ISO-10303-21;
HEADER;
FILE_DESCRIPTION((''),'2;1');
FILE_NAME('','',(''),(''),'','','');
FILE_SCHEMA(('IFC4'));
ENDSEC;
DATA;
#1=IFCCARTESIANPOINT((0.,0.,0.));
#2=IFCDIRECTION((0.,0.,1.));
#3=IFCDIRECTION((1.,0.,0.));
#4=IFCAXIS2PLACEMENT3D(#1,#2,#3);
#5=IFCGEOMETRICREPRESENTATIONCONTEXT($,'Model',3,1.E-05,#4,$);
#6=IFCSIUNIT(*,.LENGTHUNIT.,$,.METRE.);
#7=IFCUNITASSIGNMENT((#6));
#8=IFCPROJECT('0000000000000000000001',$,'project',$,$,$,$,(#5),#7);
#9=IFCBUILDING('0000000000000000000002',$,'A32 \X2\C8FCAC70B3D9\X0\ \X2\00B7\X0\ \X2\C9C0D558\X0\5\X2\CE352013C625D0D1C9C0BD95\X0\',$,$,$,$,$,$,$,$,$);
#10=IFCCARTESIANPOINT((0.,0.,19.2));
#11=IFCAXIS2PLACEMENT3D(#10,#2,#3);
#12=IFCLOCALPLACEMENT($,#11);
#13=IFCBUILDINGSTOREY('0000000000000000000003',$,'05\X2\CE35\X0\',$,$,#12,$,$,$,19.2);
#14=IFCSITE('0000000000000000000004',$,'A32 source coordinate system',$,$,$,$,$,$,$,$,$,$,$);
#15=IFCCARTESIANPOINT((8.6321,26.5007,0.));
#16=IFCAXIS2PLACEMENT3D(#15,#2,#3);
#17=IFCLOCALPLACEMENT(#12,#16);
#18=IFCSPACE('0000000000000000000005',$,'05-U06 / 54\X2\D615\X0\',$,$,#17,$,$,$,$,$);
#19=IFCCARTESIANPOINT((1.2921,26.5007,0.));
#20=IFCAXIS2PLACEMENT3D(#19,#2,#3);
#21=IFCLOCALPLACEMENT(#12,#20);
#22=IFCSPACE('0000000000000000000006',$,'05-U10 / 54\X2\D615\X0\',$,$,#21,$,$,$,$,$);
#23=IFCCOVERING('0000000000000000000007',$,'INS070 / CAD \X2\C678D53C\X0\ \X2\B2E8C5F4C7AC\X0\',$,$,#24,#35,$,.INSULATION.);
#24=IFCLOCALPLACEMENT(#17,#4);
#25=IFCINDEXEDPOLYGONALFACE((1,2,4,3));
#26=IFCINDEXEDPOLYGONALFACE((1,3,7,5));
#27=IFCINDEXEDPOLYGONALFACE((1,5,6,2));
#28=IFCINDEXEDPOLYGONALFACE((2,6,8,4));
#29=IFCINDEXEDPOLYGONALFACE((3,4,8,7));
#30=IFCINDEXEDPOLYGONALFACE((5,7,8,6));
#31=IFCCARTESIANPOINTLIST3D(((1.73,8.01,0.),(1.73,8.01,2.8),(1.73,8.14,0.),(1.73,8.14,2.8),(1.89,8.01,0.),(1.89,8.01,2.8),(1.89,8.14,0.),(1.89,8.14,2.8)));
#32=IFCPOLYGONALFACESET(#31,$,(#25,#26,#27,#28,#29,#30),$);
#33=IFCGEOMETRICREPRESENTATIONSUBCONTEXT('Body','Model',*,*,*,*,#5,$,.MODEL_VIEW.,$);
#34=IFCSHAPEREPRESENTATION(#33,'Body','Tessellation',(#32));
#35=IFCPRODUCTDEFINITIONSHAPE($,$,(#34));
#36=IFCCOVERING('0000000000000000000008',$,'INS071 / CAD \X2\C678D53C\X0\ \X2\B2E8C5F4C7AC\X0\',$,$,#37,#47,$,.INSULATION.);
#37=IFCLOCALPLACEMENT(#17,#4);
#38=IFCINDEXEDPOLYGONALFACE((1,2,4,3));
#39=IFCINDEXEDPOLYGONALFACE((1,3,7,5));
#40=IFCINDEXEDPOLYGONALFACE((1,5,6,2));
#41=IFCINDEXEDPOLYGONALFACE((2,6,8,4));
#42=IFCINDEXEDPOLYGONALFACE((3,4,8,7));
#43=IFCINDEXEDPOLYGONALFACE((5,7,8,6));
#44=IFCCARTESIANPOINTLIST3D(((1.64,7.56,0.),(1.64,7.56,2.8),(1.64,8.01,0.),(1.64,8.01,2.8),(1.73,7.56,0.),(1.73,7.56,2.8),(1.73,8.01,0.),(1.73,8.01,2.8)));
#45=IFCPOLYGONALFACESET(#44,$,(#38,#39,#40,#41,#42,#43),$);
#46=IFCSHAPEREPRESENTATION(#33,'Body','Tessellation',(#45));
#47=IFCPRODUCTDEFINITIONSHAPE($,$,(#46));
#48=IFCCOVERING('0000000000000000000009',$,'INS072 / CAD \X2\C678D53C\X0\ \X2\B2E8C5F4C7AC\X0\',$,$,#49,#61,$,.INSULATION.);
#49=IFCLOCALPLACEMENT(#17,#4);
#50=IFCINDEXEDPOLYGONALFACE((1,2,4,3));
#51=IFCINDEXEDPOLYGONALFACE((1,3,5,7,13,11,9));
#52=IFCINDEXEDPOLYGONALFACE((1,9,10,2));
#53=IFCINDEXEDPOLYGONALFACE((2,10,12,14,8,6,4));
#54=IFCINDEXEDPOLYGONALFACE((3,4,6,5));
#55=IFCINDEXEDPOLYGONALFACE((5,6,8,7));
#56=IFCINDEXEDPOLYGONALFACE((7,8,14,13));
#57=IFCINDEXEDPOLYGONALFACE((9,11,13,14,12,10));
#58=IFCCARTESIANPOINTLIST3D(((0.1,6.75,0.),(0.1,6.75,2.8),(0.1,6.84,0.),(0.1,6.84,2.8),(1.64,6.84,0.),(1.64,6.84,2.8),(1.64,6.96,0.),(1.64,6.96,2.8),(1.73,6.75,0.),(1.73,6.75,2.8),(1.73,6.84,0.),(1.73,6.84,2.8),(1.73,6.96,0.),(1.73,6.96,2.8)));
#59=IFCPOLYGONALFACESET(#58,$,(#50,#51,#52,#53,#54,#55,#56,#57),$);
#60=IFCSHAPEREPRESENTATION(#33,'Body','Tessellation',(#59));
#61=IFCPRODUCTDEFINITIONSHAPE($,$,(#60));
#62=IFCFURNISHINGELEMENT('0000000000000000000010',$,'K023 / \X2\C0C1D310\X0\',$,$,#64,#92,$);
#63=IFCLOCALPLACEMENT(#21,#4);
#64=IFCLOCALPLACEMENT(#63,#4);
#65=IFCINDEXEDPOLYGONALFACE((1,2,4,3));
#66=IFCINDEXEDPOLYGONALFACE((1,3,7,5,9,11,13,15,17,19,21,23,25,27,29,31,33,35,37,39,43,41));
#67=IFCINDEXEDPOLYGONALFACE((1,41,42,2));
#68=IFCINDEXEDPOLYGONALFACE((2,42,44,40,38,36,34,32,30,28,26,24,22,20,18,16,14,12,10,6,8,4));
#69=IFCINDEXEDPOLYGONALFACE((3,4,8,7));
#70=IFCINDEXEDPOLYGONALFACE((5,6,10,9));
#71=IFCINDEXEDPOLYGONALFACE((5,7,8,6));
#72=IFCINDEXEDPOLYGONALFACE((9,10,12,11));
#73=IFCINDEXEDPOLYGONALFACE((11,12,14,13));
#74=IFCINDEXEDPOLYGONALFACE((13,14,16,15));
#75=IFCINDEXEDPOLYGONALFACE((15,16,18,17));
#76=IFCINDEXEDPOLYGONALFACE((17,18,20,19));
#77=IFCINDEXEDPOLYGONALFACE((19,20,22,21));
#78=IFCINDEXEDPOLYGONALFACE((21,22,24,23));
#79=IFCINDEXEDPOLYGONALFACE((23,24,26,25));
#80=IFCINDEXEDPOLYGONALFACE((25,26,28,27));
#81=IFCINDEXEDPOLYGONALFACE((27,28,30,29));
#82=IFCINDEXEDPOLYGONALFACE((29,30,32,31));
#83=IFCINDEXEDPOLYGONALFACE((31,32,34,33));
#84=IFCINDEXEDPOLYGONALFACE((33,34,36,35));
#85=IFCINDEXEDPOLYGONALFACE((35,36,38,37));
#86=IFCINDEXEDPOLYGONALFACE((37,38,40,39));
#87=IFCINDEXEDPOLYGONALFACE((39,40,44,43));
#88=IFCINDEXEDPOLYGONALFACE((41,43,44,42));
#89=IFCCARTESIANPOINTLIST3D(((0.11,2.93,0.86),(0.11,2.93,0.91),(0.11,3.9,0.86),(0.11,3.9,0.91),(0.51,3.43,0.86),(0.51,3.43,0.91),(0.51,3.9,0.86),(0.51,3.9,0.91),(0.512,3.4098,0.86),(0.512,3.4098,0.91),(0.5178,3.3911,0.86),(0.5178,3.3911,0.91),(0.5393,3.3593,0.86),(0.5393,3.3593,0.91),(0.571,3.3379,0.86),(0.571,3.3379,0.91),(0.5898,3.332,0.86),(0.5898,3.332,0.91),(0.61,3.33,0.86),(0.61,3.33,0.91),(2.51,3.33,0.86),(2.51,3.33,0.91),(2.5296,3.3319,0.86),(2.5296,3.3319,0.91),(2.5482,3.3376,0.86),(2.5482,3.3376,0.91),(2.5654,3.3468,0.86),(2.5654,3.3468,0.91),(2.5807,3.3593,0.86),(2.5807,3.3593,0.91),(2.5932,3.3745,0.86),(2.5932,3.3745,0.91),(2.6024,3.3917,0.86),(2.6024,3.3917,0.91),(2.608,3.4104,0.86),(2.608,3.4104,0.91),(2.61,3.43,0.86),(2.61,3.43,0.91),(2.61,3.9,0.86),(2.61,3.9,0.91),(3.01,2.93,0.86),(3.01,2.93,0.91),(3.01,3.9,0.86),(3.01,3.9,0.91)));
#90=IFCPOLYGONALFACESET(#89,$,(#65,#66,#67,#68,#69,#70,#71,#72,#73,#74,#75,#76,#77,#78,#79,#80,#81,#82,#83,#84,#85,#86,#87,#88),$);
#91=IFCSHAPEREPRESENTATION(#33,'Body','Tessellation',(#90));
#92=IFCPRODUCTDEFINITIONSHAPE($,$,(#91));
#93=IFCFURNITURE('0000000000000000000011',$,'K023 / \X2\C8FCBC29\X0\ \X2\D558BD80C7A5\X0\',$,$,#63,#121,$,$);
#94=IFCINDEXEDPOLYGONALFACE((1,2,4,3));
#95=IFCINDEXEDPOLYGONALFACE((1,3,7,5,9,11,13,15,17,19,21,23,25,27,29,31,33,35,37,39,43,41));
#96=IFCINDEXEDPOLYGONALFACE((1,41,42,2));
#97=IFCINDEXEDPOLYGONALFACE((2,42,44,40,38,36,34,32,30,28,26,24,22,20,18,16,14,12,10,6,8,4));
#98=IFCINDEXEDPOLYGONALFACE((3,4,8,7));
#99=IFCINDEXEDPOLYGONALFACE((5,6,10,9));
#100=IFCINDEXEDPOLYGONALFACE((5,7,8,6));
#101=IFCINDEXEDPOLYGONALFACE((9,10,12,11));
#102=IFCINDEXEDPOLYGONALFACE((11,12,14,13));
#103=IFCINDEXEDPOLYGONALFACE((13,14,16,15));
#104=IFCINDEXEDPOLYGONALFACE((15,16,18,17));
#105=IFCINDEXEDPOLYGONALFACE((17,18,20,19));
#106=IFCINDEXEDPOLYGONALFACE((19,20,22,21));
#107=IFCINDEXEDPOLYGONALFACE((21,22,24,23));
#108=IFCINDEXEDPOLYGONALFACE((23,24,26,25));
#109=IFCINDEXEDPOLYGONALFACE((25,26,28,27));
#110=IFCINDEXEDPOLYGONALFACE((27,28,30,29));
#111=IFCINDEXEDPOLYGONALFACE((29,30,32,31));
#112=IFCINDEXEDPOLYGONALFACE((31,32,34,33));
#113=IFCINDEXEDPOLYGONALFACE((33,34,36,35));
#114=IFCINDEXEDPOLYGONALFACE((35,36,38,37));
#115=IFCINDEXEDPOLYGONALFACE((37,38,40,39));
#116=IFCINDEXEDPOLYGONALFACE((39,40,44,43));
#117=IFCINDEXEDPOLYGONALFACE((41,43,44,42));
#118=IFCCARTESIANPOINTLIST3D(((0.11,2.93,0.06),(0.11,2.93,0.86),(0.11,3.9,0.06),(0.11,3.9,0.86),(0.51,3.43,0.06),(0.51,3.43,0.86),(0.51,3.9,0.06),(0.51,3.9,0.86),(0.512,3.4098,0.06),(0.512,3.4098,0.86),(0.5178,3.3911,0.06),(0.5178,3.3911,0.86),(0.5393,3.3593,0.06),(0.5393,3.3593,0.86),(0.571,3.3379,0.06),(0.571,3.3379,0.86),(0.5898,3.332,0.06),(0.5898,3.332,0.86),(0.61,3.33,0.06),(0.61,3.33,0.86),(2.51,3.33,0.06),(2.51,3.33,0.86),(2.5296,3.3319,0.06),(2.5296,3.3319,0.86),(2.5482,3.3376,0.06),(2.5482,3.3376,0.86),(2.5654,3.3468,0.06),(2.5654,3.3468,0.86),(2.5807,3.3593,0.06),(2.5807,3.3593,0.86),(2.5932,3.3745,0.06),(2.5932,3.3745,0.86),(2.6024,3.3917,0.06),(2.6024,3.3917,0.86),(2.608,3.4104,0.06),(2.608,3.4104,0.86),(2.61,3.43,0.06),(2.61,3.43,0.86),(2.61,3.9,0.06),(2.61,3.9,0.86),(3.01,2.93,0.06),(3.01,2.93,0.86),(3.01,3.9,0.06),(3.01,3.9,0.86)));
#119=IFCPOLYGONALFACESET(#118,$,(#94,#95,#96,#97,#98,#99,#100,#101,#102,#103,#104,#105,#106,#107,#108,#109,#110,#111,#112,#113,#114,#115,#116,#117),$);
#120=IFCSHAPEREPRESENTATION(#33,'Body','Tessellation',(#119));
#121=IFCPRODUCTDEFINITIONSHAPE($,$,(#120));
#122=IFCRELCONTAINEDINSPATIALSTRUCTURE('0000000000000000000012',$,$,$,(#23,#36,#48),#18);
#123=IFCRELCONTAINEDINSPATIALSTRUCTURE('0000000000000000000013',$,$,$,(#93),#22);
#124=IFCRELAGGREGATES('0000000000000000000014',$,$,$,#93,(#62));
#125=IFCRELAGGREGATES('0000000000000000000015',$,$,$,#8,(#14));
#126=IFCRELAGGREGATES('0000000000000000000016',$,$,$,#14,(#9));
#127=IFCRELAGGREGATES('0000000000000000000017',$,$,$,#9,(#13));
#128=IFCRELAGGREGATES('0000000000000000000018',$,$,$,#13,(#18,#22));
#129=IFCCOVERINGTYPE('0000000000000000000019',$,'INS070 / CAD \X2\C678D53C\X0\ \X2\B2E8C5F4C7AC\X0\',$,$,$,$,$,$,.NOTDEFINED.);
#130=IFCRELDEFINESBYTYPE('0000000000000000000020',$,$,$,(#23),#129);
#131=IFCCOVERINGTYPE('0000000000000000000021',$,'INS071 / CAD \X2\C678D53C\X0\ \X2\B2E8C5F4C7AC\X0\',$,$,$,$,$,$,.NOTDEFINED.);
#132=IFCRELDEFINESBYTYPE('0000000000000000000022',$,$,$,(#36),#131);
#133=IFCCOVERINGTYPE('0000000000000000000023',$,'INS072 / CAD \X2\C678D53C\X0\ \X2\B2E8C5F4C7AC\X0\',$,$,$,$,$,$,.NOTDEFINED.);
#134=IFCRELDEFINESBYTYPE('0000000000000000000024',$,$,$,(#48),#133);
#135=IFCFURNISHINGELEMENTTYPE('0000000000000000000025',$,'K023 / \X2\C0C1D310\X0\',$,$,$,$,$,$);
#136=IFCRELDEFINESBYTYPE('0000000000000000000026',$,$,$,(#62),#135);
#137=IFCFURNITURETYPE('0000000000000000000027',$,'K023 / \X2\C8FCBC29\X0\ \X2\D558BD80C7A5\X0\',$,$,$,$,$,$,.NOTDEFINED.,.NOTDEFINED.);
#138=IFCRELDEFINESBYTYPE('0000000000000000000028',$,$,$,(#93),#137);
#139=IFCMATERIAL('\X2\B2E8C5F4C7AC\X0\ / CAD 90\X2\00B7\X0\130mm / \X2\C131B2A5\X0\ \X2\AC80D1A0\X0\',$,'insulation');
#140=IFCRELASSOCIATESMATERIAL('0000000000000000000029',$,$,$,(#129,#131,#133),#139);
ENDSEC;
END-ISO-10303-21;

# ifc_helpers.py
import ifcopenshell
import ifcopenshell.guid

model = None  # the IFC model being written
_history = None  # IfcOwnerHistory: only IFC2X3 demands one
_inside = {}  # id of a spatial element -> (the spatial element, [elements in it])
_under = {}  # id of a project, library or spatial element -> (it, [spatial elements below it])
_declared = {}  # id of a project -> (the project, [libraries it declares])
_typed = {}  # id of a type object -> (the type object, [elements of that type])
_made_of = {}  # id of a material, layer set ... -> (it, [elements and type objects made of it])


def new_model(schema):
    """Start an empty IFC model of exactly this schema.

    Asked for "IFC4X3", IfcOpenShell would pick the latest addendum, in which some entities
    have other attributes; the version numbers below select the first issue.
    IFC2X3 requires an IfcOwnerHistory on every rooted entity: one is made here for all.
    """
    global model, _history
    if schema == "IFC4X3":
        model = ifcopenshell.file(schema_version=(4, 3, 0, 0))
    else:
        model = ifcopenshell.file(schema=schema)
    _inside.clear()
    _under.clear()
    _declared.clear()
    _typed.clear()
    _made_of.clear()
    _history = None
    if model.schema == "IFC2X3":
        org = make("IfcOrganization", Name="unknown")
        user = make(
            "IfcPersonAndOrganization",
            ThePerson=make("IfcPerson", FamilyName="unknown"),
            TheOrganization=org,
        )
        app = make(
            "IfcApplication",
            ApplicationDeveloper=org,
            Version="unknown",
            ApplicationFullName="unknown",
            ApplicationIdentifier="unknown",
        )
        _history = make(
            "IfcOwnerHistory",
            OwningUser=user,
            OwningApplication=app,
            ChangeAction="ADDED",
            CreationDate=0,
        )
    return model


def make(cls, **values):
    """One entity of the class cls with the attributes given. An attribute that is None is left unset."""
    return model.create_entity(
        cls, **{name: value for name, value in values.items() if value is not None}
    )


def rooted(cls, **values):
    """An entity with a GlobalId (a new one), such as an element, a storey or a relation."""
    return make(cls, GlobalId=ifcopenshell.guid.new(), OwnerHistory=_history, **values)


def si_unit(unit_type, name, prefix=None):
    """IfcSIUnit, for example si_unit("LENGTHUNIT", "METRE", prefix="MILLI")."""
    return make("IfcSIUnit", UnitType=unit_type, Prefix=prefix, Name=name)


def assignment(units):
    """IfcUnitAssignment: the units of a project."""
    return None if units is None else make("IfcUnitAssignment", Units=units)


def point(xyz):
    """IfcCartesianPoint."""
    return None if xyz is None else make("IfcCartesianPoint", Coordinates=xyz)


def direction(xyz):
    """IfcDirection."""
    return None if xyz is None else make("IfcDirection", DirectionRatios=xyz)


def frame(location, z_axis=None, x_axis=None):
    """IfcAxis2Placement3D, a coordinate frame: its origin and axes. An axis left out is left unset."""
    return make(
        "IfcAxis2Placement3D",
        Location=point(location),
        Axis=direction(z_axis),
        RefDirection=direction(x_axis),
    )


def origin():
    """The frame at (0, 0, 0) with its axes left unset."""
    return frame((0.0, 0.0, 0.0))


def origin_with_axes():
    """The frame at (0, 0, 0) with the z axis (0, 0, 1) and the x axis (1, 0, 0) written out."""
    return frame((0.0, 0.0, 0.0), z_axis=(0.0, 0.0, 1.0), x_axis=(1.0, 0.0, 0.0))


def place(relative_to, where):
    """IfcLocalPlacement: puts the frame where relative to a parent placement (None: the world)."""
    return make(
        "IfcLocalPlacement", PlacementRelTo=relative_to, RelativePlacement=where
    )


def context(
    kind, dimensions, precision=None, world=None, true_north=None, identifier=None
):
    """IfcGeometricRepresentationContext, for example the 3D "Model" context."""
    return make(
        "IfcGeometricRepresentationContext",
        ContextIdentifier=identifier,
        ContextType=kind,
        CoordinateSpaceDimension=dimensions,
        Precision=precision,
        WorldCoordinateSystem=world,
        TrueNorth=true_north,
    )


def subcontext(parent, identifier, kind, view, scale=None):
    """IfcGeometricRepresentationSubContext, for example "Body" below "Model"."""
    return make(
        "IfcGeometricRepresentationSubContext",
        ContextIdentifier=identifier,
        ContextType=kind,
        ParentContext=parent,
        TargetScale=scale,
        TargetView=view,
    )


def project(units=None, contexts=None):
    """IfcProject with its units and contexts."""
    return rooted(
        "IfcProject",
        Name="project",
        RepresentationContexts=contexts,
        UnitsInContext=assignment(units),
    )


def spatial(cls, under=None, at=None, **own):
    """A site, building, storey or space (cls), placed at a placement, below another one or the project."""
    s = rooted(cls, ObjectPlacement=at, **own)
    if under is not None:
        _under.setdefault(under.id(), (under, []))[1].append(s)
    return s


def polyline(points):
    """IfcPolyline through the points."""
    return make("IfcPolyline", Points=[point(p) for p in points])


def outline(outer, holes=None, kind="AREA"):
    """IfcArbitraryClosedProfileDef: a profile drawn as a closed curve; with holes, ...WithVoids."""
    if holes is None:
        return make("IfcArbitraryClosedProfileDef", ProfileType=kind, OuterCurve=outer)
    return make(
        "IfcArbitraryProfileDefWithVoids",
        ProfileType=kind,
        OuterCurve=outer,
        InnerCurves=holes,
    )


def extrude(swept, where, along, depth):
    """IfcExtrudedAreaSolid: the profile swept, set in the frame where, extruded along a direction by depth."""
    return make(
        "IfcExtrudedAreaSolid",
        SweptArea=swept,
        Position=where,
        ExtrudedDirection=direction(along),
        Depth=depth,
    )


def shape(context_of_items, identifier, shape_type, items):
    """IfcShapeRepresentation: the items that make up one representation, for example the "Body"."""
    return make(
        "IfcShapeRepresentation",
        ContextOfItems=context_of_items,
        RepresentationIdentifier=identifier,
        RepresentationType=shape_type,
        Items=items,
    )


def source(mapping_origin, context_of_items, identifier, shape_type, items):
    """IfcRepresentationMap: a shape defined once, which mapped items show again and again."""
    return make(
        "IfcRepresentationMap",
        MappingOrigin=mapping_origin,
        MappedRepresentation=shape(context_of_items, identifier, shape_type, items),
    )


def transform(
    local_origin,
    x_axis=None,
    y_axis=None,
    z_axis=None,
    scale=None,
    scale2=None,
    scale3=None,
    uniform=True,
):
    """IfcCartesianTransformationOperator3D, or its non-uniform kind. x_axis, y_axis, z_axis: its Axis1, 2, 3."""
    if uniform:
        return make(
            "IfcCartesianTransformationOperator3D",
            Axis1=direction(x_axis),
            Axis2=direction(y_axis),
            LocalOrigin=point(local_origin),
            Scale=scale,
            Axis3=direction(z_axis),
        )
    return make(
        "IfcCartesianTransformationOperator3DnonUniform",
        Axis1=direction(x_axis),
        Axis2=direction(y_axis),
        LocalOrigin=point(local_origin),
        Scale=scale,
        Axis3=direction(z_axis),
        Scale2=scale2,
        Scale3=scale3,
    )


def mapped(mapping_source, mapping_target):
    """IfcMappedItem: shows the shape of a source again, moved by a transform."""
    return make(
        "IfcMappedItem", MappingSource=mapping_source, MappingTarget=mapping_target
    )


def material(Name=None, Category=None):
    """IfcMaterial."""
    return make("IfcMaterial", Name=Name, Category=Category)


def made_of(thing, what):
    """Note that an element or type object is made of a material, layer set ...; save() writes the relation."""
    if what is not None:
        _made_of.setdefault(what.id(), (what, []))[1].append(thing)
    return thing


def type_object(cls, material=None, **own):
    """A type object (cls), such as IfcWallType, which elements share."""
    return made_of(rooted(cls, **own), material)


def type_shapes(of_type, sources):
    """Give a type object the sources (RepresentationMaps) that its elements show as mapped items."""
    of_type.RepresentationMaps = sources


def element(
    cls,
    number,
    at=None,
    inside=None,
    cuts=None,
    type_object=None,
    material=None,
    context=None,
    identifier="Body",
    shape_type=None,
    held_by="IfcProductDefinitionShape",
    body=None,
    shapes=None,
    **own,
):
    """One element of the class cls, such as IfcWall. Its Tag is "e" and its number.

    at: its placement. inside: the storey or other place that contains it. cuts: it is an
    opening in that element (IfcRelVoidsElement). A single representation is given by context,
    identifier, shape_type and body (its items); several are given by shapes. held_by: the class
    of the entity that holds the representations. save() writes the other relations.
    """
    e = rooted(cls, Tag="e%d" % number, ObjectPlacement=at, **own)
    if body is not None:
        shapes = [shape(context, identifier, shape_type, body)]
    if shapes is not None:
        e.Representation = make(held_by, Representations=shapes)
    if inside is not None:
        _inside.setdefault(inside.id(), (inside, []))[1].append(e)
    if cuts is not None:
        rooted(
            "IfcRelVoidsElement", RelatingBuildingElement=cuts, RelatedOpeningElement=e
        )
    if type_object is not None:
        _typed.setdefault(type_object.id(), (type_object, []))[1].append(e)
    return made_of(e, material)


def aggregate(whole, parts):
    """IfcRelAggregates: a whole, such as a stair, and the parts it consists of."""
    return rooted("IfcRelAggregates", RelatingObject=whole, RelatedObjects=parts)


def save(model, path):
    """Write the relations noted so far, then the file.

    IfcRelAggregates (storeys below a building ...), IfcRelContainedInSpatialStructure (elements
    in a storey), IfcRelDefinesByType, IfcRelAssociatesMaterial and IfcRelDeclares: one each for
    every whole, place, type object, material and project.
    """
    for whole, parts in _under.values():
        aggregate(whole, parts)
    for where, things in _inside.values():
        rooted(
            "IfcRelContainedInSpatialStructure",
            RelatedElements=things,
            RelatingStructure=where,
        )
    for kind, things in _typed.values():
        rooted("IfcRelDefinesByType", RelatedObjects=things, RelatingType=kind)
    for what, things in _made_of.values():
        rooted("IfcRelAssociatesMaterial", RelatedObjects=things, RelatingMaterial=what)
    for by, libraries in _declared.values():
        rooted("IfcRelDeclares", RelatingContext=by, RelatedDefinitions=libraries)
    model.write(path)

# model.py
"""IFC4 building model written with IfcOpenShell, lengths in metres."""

from ifc_helpers import new_model, si_unit, frame, origin, origin_with_axes, place, context, subcontext, project, spatial, polyline, outline, extrude, source, transform, mapped, material, type_object, type_shapes, element, aggregate, save


model = new_model("IFC4")

# Units and contexts
model_context = context("Model", 3, precision=1e-05, world=origin_with_axes())
body_context = subcontext(model_context, "Body", "Model", "MODEL_VIEW")
ifc_project = project(units=[si_unit("LENGTHUNIT", "METRE")], contexts=[model_context])

# Site, building, storey, space
storey_placement = place(None, frame((0.0, 0.0, 19.2), z_axis=(0.0, 0.0, 1.0), x_axis=(1.0, 0.0, 0.0)))
space_1_placement = place(storey_placement, frame((8.6321, 26.5007, 0.0), z_axis=(0.0, 0.0, 1.0), x_axis=(1.0, 0.0, 0.0)))
site = spatial("IfcSite", under=ifc_project, Name="A32 source coordinate system")
building = spatial("IfcBuilding", under=site, Name="A32 주거동 · 지하5층–옥탑지붕")
storey = spatial("IfcBuildingStorey", under=building, at=storey_placement, Name="05층", Elevation=19.2)
space_1 = spatial("IfcSpace", under=storey, at=space_1_placement, Name="05-U06 / 54형")

# Coverings
ifc_material = material(Name="단열재 / CAD 90·130mm / 성능 검토", Category="insulation")
covering_type_1 = type_object("IfcCoveringType", Name="INS070 / CAD 외피 단열재", PredefinedType="NOTDEFINED", material=ifc_material)
shared_shape_1 = source(origin(), body_context, "Body", "SweptSolid", [
    extrude(outline(polyline([(1.73, 8.14), (1.89, 8.14), (1.89, 8.01), (1.73, 8.01), (1.73, 8.14)])), origin(), (0.0, 0.0, 1.0), 2.8),
])
type_shapes(covering_type_1, [shared_shape_1])
covering_1_placement = place(space_1_placement, origin_with_axes())
element("IfcCovering", 1, at=covering_1_placement, inside=space_1, type_object=covering_type_1, Name="INS070 / CAD 외피 단열재", PredefinedType="INSULATION", context=body_context, shape_type="MappedRepresentation", body=[
    mapped(shared_shape_1, transform((0.0, 0.0, 0.0), scale=1.0)),
])
covering_type_2 = type_object("IfcCoveringType", Name="INS071 / CAD 외피 단열재", PredefinedType="NOTDEFINED", material=ifc_material)
shared_shape_2 = source(origin(), body_context, "Body", "SweptSolid", [
    extrude(outline(polyline([(1.73, 7.56), (1.64, 7.56), (1.64, 8.01), (1.73, 8.01), (1.73, 7.56)])), origin(), (0.0, 0.0, 1.0), 2.8),
])
type_shapes(covering_type_2, [shared_shape_2])
covering_2_placement = place(space_1_placement, origin_with_axes())
element("IfcCovering", 2, at=covering_2_placement, inside=space_1, type_object=covering_type_2, Name="INS071 / CAD 외피 단열재", PredefinedType="INSULATION", context=body_context, shape_type="MappedRepresentation", body=[
    mapped(shared_shape_2, transform((0.0, 0.0, 0.0), scale=1.0)),
])
covering_type_3 = type_object("IfcCoveringType", Name="INS072 / CAD 외피 단열재", PredefinedType="NOTDEFINED", material=ifc_material)
shared_shape_3 = source(origin(), body_context, "Body", "SweptSolid", [
    extrude(outline(polyline([(1.64, 6.84), (1.64, 6.96), (1.73, 6.96), (1.73, 6.84), (1.73, 6.75), (0.1, 6.75), (0.1, 6.84), (1.64, 6.84)])), origin(), (0.0, 0.0, 1.0), 2.8),
])
type_shapes(covering_type_3, [shared_shape_3])
covering_3_placement = place(space_1_placement, origin_with_axes())
element("IfcCovering", 3, at=covering_3_placement, inside=space_1, type_object=covering_type_3, Name="INS072 / CAD 외피 단열재", PredefinedType="INSULATION", context=body_context, shape_type="MappedRepresentation", body=[
    mapped(shared_shape_3, transform((0.0, 0.0, 0.0), scale=1.0)),
])

# Shared definitions
space_2_placement = place(storey_placement, frame((1.2921, 26.5007, 0.0), z_axis=(0.0, 0.0, 1.0), x_axis=(1.0, 0.0, 0.0)))

# Furnishing element
furnishing_element_type_1 = type_object("IfcFurnishingElementType", Name="K023 / 상판")
shared_shape_4 = source(origin(), body_context, "Body", "SweptSolid", [
    extrude(outline(polyline([(0.51, 3.43), (0.512, 3.4098), (0.5178, 3.3911), (0.5393, 3.3593), (0.571, 3.3379), (0.5898, 3.332), (0.61, 3.33), (2.51, 3.33), (2.5296, 3.3319), (2.5482, 3.3376), (2.5654, 3.3468), (2.5807, 3.3593), (2.5932, 3.3745), (2.6024, 3.3917), (2.608, 3.4104), (2.61, 3.43), (2.61, 3.9), (3.01, 3.9), (3.01, 2.93), (0.11, 2.93), (0.11, 3.9), (0.51, 3.9), (0.51, 3.43)])), frame((0.0, 0.0, 0.86)), (0.0, 0.0, 1.0), 0.05),
])
type_shapes(furnishing_element_type_1, [shared_shape_4])
furniture_1_placement = place(space_2_placement, origin_with_axes())
furnishing_1_placement = place(furniture_1_placement, origin_with_axes())
furnishing_1 = element("IfcFurnishingElement", 4, at=furnishing_1_placement, type_object=furnishing_element_type_1, Name="K023 / 상판", context=body_context, shape_type="MappedRepresentation", body=[
    mapped(shared_shape_4, transform((0.0, 0.0, 0.0), scale=1.0)),
])

# Shared definitions
space_2 = spatial("IfcSpace", under=storey, at=space_2_placement, Name="05-U10 / 54형")

# Furniture
furniture_type_1 = type_object("IfcFurnitureType", Name="K023 / 주방 하부장", AssemblyPlace="NOTDEFINED", PredefinedType="NOTDEFINED")
shared_shape_5 = source(origin(), body_context, "Body", "SweptSolid", [
    extrude(outline(polyline([(0.51, 3.9), (0.51, 3.43), (0.512, 3.4098), (0.5178, 3.3911), (0.5393, 3.3593), (0.571, 3.3379), (0.5898, 3.332), (0.61, 3.33), (2.51, 3.33), (2.5296, 3.3319), (2.5482, 3.3376), (2.5654, 3.3468), (2.5807, 3.3593), (2.5932, 3.3745), (2.6024, 3.3917), (2.608, 3.4104), (2.61, 3.43), (2.61, 3.9), (3.01, 3.9), (3.01, 2.93), (0.11, 2.93), (0.11, 3.9), (0.51, 3.9)])), frame((0.0, 0.0, 0.06)), (0.0, 0.0, 1.0), 0.8),
])
type_shapes(furniture_type_1, [shared_shape_5])
furniture_1 = element("IfcFurniture", 5, at=furniture_1_placement, inside=space_2, type_object=furniture_type_1, Name="K023 / 주방 하부장", context=body_context, shape_type="MappedRepresentation", body=[
    mapped(shared_shape_5, transform((0.0, 0.0, 0.0), scale=1.0)),
])
aggregate(furniture_1, [furnishing_1])

save(model, "model.ifc")
